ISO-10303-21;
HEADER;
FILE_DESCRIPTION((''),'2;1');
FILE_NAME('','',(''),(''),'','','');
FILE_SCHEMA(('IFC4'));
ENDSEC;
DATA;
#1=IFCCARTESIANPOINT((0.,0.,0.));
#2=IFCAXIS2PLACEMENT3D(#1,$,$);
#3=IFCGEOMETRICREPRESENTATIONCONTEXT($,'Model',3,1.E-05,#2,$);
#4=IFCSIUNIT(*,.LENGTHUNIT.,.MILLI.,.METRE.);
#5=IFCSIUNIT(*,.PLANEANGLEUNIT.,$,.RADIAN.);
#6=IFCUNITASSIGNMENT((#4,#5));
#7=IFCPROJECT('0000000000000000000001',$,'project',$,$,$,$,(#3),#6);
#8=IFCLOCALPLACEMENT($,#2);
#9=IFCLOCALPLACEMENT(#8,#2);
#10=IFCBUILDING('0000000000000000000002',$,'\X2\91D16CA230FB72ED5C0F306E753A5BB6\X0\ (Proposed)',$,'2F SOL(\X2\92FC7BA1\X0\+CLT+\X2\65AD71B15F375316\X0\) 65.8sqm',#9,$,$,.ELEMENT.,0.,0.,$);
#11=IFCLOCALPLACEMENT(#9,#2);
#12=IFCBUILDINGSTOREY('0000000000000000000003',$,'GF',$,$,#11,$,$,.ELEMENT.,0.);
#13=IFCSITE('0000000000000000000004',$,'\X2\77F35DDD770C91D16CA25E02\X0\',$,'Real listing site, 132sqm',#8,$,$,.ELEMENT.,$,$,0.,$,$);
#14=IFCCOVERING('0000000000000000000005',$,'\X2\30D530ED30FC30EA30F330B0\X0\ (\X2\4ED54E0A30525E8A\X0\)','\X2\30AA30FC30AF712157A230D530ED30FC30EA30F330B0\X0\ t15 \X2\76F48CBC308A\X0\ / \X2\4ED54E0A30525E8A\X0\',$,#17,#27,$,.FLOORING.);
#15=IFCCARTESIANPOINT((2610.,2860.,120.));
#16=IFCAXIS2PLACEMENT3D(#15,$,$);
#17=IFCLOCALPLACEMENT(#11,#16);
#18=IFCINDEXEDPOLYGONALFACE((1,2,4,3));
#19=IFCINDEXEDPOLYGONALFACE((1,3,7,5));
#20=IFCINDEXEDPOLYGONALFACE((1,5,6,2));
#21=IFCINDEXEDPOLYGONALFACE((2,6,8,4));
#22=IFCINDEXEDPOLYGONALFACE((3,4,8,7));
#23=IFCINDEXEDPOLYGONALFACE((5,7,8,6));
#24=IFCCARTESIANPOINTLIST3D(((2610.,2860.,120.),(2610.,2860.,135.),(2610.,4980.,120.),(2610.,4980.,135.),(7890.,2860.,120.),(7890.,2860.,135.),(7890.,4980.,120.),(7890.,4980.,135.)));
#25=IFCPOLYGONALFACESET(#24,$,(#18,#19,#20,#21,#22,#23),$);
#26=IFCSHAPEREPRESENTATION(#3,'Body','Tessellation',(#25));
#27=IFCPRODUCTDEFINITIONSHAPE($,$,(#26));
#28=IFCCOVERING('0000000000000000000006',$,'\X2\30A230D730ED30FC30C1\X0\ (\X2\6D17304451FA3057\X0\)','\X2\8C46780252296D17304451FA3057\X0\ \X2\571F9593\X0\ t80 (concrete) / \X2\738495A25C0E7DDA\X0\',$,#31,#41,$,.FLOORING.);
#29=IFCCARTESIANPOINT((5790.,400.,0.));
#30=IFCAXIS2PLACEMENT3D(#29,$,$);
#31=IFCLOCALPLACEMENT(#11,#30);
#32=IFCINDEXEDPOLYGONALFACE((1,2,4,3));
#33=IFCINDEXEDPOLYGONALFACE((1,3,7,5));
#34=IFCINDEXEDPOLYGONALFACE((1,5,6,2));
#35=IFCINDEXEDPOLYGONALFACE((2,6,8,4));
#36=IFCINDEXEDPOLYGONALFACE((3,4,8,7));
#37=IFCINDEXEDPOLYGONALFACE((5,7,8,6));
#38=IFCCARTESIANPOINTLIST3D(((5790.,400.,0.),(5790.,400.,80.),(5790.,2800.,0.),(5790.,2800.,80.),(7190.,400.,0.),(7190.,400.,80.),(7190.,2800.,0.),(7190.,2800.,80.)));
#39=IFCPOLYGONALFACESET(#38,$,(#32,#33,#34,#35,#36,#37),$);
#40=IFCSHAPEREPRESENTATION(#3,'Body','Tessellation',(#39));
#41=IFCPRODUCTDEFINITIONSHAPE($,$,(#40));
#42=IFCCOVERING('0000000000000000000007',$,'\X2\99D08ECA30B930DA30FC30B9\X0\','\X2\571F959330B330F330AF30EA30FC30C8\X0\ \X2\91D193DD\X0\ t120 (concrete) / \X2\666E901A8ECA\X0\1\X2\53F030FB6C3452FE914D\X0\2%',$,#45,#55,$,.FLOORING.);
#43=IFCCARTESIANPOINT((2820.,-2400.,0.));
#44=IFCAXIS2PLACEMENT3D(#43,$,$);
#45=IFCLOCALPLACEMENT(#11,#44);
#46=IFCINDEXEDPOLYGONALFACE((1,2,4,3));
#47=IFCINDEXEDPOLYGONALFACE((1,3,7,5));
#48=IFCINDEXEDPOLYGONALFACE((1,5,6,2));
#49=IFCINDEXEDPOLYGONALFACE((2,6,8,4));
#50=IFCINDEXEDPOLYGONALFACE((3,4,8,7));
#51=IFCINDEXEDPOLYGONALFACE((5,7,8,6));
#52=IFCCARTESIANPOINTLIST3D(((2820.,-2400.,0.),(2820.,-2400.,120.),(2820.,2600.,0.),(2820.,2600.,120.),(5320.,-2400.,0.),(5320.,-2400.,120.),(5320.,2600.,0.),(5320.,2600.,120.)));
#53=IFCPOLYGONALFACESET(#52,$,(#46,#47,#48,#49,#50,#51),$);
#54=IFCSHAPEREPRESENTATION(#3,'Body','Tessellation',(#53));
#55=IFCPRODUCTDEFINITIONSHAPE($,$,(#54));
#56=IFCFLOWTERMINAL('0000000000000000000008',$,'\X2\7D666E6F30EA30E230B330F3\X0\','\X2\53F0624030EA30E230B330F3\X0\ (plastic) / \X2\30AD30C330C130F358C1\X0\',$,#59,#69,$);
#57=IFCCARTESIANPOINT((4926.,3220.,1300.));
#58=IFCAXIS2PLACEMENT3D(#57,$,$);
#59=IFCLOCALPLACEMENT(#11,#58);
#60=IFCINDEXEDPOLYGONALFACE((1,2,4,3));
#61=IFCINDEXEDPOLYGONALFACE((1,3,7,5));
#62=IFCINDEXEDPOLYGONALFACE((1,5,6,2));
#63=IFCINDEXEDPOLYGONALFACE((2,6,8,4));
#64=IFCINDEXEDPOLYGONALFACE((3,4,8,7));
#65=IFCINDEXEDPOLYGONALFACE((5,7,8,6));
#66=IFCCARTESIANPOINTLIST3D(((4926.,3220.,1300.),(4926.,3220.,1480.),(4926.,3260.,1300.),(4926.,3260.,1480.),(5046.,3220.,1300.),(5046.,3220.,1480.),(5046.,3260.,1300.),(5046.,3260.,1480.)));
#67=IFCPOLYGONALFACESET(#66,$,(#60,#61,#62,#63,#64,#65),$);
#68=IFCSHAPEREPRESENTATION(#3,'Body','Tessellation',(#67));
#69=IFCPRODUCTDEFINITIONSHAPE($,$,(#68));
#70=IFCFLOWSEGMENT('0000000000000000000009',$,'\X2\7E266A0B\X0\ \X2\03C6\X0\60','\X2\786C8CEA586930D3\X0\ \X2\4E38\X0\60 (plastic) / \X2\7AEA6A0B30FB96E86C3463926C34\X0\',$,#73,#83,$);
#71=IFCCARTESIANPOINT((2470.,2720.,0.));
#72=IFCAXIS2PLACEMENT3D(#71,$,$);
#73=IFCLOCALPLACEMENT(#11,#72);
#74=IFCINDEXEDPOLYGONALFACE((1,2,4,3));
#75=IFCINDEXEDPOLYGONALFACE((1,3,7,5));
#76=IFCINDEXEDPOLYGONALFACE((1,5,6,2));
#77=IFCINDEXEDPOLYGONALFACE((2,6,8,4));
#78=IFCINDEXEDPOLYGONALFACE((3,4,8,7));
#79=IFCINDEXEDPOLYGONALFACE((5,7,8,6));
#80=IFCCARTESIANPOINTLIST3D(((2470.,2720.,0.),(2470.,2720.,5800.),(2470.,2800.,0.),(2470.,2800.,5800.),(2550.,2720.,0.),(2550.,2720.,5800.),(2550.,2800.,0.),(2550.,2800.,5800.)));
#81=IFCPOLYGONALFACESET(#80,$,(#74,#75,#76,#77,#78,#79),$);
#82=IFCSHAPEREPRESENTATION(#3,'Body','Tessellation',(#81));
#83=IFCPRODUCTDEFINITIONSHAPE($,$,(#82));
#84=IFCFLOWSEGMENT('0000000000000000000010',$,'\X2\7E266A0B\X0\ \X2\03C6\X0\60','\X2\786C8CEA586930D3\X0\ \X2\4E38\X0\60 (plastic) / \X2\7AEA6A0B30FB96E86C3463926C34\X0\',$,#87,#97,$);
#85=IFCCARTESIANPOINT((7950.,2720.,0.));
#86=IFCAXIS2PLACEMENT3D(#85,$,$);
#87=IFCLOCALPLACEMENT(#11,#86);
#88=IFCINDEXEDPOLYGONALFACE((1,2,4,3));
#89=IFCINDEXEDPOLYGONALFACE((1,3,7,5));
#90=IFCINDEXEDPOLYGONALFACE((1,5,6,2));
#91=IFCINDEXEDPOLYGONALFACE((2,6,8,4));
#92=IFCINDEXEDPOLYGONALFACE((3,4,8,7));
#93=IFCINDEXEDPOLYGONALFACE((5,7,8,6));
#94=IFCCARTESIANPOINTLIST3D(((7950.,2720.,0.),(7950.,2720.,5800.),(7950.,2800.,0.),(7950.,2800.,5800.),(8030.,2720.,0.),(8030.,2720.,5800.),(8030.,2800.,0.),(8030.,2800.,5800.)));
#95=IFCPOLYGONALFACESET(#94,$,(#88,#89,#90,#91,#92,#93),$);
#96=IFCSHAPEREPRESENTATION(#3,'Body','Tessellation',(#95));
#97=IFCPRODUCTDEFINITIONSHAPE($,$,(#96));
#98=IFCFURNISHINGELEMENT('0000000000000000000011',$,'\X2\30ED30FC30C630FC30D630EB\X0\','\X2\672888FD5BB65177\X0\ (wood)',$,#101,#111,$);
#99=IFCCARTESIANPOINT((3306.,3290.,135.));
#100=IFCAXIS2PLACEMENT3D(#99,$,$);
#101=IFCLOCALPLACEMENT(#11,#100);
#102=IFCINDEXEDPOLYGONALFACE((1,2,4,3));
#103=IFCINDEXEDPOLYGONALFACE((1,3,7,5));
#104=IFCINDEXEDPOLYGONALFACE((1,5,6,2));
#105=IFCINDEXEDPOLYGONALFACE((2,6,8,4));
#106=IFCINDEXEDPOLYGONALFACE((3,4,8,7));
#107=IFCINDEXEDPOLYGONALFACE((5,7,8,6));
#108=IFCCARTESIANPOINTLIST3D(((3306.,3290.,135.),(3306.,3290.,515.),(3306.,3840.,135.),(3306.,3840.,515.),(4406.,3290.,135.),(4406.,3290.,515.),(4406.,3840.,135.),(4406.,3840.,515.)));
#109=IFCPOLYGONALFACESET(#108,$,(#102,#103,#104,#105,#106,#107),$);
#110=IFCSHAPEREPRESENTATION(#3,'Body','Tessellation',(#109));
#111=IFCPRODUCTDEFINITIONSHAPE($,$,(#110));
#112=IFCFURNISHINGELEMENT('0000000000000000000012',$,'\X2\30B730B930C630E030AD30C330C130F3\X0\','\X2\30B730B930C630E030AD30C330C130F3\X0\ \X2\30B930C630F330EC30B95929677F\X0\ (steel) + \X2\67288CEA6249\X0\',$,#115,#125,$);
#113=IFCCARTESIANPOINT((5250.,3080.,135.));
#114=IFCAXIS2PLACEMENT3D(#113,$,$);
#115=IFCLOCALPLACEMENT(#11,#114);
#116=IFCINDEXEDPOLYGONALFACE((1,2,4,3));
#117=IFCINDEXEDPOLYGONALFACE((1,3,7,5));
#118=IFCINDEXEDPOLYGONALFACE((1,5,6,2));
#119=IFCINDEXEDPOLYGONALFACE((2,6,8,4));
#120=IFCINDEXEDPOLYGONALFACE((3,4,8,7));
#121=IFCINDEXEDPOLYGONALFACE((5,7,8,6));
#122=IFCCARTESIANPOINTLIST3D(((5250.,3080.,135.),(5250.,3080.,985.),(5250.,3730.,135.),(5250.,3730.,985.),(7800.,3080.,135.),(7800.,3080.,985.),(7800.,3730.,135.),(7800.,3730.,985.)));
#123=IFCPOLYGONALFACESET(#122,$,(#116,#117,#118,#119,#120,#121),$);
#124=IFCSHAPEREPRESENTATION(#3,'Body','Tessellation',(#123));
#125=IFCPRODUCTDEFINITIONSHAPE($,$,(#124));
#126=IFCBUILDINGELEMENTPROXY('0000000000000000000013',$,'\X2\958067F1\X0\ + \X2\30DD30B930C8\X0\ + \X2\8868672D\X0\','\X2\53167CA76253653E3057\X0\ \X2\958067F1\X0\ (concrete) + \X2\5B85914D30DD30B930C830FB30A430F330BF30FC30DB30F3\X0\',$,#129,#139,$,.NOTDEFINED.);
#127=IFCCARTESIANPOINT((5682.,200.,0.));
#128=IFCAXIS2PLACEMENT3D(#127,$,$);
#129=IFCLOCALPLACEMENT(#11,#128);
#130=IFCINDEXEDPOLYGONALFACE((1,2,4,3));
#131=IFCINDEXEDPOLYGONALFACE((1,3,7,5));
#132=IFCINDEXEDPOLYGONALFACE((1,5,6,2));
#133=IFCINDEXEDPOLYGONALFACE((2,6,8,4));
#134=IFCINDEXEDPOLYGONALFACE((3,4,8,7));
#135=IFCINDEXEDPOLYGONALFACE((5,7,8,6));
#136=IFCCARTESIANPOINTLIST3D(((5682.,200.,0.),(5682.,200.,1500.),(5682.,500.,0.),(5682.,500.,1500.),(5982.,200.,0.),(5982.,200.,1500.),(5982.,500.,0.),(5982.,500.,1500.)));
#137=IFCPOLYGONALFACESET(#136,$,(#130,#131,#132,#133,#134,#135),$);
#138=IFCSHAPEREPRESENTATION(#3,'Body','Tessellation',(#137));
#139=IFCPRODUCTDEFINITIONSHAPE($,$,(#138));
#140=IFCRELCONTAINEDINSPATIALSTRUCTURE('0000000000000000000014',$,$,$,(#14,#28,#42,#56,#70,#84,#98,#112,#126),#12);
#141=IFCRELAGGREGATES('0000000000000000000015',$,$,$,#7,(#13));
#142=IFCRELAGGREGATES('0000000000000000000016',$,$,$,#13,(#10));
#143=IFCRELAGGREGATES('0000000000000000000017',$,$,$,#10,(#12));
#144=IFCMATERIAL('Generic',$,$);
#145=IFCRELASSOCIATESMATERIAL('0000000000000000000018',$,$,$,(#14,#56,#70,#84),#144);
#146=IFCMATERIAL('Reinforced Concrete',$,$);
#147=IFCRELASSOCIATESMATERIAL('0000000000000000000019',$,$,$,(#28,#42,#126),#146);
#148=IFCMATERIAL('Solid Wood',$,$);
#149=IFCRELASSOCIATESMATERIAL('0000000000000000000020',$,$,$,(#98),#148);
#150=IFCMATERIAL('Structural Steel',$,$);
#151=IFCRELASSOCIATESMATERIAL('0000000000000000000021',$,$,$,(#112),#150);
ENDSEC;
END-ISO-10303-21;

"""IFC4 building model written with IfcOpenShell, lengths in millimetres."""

from ifc_helpers import new_model, si_unit, frame, frame_2d, origin, place, context, project, spatial, rectangle, extrude, material, element, save


model = new_model("IFC4")

# Units and contexts
model_context = context("Model", 3, precision=1e-05, world=origin())
ifc_project = project(units=[si_unit("LENGTHUNIT", "METRE", prefix="MILLI"), si_unit("PLANEANGLEUNIT", "RADIAN")], contexts=[model_context])

# Site, building, storey
site_placement = place(None, origin())
site = spatial("IfcSite", under=ifc_project, at=site_placement, Name="石川県金沢市", ObjectType="Real listing site, 132sqm", CompositionType="ELEMENT", RefElevation=0.0)
building_placement = place(site_placement, origin())
building = spatial("IfcBuilding", under=site, at=building_placement, Name="金沢・狭小の町家 (Proposed)", ObjectType="2F SOL(鋼管+CLT+断熱強化) 65.8sqm", CompositionType="ELEMENT", ElevationOfRefHeight=0.0, ElevationOfTerrain=0.0)
storey_placement = place(building_placement, origin())
storey = spatial("IfcBuildingStorey", under=building, at=storey_placement, Name="GF", CompositionType="ELEMENT", Elevation=0.0)

# Shared definitions
ifc_material_1 = material(Name="Solid Wood")

# Shared definitions
ifc_material_2 = material(Name="Reinforced Concrete")

# Coverings
ifc_material_3 = material(Name="Generic")
covering_1_placement = place(storey_placement, frame((2610.0, 2860.0, 120.0)))
element("IfcCovering", 1, at=covering_1_placement, inside=storey, material=ifc_material_3, Name="フローリング (仕上げ床)", Description="オーク無垢フローリング t15 直貼り / 仕上げ床", PredefinedType="FLOORING", context=model_context, shape_type="SweptSolid", body=[
    extrude(rectangle(XDim=5280.0, YDim=2120.0, at=frame_2d((2640.0, 1060.0))), frame((2610.0, 2860.0, 120.0)), (0.0, 0.0, 1.0), 15.0),
])
covering_2_placement = place(storey_placement, frame((5790.0, 400.0, 0.0)))
element("IfcCovering", 2, at=covering_2_placement, inside=storey, material=ifc_material_2, Name="アプローチ (洗い出し)", Description="豆砂利洗い出し 土間 t80 (concrete) / 玄関導線", PredefinedType="FLOORING", context=model_context, shape_type="SweptSolid", body=[
    extrude(rectangle(XDim=1400.0, YDim=2400.0, at=frame_2d((700.0, 1200.0))), frame((5790.0, 400.0, 0.0)), (0.0, 0.0, 1.0), 80.0),
])
covering_3_placement = place(storey_placement, frame((2820.0, -2400.0, 0.0)))
element("IfcCovering", 3, at=covering_3_placement, inside=storey, material=ifc_material_2, Name="駐車スペース", Description="土間コンクリート 金鏝 t120 (concrete) / 普通車1台・水勾配2%", PredefinedType="FLOORING", context=model_context, shape_type="SweptSolid", body=[
    extrude(rectangle(XDim=2500.0, YDim=5000.0, at=frame_2d((1250.0, 2500.0))), frame((2820.0, -2400.0, 0.0)), (0.0, 0.0, 1.0), 120.0),
])

# Flow terminal
flow_terminal_placement = place(storey_placement, frame((4926.0, 3220.0, 1300.0)))
element("IfcFlowTerminal", 4, at=flow_terminal_placement, inside=storey, material=ifc_material_3, Name="給湯リモコン", Description="台所リモコン (plastic) / キッチン壁", context=model_context, shape_type="SweptSolid", body=[
    extrude(rectangle(XDim=120.0, YDim=40.0, at=frame_2d((60.0, 20.0))), frame((4926.0, 3220.0, 1300.0)), (0.0, 0.0, 1.0), 180.0),
])

# Flow segments
flow_segment_1_placement = place(storey_placement, frame((2470.0, 2720.0, 0.0)))
element("IfcFlowSegment", 5, at=flow_segment_1_placement, inside=storey, material=ifc_material_3, Name="縦樋 φ60", Description="硬質塩ビ 丸60 (plastic) / 竪樋・雨水排水", context=model_context, shape_type="SweptSolid", body=[
    extrude(rectangle(XDim=80.0, YDim=80.0, at=frame_2d((40.0, 40.0))), frame((2470.0, 2720.0, 0.0)), (0.0, 0.0, 1.0), 5800.0),
])
flow_segment_2_placement = place(storey_placement, frame((7950.0, 2720.0, 0.0)))
element("IfcFlowSegment", 6, at=flow_segment_2_placement, inside=storey, material=ifc_material_3, Name="縦樋 φ60", Description="硬質塩ビ 丸60 (plastic) / 竪樋・雨水排水", context=model_context, shape_type="SweptSolid", body=[
    extrude(rectangle(XDim=80.0, YDim=80.0, at=frame_2d((40.0, 40.0))), frame((7950.0, 2720.0, 0.0)), (0.0, 0.0, 1.0), 5800.0),
])

# Furnishing elements
furnishing_1_placement = place(storey_placement, frame((3306.0, 3290.0, 135.0)))
element("IfcFurnishingElement", 7, at=furnishing_1_placement, inside=storey, material=ifc_material_1, Name="ローテーブル", Description="木製家具 (wood)", context=model_context, shape_type="SweptSolid", body=[
    extrude(rectangle(XDim=1100.0, YDim=550.0, at=frame_2d((550.0, 275.0))), frame((3306.0, 3290.0, 135.0)), (0.0, 0.0, 1.0), 380.0),
])
ifc_material_4 = material(Name="Structural Steel")
furnishing_2_placement = place(storey_placement, frame((5250.0, 3080.0, 135.0)))
element("IfcFurnishingElement", 8, at=furnishing_2_placement, inside=storey, material=ifc_material_4, Name="システムキッチン", Description="システムキッチン ステンレス天板 (steel) + 木質扉", context=model_context, shape_type="SweptSolid", body=[
    extrude(rectangle(XDim=2550.0, YDim=650.0, at=frame_2d((1275.0, 325.0))), frame((5250.0, 3080.0, 135.0)), (0.0, 0.0, 1.0), 850.0),
])

# Building element proxy
proxy_placement = place(storey_placement, frame((5682.0, 200.0, 0.0)))
element("IfcBuildingElementProxy", 9, at=proxy_placement, inside=storey, material=ifc_material_2, Name="門柱 + ポスト + 表札", Description="化粧打放し 門柱 (concrete) + 宅配ポスト・インターホン", PredefinedType="NOTDEFINED", context=model_context, shape_type="SweptSolid", body=[
    extrude(rectangle(XDim=300.0, YDim=300.0, at=frame_2d((150.0, 150.0))), frame((5682.0, 200.0, 0.0)), (0.0, 0.0, 1.0), 1500.0),
])

save(model, "model.ifc")
